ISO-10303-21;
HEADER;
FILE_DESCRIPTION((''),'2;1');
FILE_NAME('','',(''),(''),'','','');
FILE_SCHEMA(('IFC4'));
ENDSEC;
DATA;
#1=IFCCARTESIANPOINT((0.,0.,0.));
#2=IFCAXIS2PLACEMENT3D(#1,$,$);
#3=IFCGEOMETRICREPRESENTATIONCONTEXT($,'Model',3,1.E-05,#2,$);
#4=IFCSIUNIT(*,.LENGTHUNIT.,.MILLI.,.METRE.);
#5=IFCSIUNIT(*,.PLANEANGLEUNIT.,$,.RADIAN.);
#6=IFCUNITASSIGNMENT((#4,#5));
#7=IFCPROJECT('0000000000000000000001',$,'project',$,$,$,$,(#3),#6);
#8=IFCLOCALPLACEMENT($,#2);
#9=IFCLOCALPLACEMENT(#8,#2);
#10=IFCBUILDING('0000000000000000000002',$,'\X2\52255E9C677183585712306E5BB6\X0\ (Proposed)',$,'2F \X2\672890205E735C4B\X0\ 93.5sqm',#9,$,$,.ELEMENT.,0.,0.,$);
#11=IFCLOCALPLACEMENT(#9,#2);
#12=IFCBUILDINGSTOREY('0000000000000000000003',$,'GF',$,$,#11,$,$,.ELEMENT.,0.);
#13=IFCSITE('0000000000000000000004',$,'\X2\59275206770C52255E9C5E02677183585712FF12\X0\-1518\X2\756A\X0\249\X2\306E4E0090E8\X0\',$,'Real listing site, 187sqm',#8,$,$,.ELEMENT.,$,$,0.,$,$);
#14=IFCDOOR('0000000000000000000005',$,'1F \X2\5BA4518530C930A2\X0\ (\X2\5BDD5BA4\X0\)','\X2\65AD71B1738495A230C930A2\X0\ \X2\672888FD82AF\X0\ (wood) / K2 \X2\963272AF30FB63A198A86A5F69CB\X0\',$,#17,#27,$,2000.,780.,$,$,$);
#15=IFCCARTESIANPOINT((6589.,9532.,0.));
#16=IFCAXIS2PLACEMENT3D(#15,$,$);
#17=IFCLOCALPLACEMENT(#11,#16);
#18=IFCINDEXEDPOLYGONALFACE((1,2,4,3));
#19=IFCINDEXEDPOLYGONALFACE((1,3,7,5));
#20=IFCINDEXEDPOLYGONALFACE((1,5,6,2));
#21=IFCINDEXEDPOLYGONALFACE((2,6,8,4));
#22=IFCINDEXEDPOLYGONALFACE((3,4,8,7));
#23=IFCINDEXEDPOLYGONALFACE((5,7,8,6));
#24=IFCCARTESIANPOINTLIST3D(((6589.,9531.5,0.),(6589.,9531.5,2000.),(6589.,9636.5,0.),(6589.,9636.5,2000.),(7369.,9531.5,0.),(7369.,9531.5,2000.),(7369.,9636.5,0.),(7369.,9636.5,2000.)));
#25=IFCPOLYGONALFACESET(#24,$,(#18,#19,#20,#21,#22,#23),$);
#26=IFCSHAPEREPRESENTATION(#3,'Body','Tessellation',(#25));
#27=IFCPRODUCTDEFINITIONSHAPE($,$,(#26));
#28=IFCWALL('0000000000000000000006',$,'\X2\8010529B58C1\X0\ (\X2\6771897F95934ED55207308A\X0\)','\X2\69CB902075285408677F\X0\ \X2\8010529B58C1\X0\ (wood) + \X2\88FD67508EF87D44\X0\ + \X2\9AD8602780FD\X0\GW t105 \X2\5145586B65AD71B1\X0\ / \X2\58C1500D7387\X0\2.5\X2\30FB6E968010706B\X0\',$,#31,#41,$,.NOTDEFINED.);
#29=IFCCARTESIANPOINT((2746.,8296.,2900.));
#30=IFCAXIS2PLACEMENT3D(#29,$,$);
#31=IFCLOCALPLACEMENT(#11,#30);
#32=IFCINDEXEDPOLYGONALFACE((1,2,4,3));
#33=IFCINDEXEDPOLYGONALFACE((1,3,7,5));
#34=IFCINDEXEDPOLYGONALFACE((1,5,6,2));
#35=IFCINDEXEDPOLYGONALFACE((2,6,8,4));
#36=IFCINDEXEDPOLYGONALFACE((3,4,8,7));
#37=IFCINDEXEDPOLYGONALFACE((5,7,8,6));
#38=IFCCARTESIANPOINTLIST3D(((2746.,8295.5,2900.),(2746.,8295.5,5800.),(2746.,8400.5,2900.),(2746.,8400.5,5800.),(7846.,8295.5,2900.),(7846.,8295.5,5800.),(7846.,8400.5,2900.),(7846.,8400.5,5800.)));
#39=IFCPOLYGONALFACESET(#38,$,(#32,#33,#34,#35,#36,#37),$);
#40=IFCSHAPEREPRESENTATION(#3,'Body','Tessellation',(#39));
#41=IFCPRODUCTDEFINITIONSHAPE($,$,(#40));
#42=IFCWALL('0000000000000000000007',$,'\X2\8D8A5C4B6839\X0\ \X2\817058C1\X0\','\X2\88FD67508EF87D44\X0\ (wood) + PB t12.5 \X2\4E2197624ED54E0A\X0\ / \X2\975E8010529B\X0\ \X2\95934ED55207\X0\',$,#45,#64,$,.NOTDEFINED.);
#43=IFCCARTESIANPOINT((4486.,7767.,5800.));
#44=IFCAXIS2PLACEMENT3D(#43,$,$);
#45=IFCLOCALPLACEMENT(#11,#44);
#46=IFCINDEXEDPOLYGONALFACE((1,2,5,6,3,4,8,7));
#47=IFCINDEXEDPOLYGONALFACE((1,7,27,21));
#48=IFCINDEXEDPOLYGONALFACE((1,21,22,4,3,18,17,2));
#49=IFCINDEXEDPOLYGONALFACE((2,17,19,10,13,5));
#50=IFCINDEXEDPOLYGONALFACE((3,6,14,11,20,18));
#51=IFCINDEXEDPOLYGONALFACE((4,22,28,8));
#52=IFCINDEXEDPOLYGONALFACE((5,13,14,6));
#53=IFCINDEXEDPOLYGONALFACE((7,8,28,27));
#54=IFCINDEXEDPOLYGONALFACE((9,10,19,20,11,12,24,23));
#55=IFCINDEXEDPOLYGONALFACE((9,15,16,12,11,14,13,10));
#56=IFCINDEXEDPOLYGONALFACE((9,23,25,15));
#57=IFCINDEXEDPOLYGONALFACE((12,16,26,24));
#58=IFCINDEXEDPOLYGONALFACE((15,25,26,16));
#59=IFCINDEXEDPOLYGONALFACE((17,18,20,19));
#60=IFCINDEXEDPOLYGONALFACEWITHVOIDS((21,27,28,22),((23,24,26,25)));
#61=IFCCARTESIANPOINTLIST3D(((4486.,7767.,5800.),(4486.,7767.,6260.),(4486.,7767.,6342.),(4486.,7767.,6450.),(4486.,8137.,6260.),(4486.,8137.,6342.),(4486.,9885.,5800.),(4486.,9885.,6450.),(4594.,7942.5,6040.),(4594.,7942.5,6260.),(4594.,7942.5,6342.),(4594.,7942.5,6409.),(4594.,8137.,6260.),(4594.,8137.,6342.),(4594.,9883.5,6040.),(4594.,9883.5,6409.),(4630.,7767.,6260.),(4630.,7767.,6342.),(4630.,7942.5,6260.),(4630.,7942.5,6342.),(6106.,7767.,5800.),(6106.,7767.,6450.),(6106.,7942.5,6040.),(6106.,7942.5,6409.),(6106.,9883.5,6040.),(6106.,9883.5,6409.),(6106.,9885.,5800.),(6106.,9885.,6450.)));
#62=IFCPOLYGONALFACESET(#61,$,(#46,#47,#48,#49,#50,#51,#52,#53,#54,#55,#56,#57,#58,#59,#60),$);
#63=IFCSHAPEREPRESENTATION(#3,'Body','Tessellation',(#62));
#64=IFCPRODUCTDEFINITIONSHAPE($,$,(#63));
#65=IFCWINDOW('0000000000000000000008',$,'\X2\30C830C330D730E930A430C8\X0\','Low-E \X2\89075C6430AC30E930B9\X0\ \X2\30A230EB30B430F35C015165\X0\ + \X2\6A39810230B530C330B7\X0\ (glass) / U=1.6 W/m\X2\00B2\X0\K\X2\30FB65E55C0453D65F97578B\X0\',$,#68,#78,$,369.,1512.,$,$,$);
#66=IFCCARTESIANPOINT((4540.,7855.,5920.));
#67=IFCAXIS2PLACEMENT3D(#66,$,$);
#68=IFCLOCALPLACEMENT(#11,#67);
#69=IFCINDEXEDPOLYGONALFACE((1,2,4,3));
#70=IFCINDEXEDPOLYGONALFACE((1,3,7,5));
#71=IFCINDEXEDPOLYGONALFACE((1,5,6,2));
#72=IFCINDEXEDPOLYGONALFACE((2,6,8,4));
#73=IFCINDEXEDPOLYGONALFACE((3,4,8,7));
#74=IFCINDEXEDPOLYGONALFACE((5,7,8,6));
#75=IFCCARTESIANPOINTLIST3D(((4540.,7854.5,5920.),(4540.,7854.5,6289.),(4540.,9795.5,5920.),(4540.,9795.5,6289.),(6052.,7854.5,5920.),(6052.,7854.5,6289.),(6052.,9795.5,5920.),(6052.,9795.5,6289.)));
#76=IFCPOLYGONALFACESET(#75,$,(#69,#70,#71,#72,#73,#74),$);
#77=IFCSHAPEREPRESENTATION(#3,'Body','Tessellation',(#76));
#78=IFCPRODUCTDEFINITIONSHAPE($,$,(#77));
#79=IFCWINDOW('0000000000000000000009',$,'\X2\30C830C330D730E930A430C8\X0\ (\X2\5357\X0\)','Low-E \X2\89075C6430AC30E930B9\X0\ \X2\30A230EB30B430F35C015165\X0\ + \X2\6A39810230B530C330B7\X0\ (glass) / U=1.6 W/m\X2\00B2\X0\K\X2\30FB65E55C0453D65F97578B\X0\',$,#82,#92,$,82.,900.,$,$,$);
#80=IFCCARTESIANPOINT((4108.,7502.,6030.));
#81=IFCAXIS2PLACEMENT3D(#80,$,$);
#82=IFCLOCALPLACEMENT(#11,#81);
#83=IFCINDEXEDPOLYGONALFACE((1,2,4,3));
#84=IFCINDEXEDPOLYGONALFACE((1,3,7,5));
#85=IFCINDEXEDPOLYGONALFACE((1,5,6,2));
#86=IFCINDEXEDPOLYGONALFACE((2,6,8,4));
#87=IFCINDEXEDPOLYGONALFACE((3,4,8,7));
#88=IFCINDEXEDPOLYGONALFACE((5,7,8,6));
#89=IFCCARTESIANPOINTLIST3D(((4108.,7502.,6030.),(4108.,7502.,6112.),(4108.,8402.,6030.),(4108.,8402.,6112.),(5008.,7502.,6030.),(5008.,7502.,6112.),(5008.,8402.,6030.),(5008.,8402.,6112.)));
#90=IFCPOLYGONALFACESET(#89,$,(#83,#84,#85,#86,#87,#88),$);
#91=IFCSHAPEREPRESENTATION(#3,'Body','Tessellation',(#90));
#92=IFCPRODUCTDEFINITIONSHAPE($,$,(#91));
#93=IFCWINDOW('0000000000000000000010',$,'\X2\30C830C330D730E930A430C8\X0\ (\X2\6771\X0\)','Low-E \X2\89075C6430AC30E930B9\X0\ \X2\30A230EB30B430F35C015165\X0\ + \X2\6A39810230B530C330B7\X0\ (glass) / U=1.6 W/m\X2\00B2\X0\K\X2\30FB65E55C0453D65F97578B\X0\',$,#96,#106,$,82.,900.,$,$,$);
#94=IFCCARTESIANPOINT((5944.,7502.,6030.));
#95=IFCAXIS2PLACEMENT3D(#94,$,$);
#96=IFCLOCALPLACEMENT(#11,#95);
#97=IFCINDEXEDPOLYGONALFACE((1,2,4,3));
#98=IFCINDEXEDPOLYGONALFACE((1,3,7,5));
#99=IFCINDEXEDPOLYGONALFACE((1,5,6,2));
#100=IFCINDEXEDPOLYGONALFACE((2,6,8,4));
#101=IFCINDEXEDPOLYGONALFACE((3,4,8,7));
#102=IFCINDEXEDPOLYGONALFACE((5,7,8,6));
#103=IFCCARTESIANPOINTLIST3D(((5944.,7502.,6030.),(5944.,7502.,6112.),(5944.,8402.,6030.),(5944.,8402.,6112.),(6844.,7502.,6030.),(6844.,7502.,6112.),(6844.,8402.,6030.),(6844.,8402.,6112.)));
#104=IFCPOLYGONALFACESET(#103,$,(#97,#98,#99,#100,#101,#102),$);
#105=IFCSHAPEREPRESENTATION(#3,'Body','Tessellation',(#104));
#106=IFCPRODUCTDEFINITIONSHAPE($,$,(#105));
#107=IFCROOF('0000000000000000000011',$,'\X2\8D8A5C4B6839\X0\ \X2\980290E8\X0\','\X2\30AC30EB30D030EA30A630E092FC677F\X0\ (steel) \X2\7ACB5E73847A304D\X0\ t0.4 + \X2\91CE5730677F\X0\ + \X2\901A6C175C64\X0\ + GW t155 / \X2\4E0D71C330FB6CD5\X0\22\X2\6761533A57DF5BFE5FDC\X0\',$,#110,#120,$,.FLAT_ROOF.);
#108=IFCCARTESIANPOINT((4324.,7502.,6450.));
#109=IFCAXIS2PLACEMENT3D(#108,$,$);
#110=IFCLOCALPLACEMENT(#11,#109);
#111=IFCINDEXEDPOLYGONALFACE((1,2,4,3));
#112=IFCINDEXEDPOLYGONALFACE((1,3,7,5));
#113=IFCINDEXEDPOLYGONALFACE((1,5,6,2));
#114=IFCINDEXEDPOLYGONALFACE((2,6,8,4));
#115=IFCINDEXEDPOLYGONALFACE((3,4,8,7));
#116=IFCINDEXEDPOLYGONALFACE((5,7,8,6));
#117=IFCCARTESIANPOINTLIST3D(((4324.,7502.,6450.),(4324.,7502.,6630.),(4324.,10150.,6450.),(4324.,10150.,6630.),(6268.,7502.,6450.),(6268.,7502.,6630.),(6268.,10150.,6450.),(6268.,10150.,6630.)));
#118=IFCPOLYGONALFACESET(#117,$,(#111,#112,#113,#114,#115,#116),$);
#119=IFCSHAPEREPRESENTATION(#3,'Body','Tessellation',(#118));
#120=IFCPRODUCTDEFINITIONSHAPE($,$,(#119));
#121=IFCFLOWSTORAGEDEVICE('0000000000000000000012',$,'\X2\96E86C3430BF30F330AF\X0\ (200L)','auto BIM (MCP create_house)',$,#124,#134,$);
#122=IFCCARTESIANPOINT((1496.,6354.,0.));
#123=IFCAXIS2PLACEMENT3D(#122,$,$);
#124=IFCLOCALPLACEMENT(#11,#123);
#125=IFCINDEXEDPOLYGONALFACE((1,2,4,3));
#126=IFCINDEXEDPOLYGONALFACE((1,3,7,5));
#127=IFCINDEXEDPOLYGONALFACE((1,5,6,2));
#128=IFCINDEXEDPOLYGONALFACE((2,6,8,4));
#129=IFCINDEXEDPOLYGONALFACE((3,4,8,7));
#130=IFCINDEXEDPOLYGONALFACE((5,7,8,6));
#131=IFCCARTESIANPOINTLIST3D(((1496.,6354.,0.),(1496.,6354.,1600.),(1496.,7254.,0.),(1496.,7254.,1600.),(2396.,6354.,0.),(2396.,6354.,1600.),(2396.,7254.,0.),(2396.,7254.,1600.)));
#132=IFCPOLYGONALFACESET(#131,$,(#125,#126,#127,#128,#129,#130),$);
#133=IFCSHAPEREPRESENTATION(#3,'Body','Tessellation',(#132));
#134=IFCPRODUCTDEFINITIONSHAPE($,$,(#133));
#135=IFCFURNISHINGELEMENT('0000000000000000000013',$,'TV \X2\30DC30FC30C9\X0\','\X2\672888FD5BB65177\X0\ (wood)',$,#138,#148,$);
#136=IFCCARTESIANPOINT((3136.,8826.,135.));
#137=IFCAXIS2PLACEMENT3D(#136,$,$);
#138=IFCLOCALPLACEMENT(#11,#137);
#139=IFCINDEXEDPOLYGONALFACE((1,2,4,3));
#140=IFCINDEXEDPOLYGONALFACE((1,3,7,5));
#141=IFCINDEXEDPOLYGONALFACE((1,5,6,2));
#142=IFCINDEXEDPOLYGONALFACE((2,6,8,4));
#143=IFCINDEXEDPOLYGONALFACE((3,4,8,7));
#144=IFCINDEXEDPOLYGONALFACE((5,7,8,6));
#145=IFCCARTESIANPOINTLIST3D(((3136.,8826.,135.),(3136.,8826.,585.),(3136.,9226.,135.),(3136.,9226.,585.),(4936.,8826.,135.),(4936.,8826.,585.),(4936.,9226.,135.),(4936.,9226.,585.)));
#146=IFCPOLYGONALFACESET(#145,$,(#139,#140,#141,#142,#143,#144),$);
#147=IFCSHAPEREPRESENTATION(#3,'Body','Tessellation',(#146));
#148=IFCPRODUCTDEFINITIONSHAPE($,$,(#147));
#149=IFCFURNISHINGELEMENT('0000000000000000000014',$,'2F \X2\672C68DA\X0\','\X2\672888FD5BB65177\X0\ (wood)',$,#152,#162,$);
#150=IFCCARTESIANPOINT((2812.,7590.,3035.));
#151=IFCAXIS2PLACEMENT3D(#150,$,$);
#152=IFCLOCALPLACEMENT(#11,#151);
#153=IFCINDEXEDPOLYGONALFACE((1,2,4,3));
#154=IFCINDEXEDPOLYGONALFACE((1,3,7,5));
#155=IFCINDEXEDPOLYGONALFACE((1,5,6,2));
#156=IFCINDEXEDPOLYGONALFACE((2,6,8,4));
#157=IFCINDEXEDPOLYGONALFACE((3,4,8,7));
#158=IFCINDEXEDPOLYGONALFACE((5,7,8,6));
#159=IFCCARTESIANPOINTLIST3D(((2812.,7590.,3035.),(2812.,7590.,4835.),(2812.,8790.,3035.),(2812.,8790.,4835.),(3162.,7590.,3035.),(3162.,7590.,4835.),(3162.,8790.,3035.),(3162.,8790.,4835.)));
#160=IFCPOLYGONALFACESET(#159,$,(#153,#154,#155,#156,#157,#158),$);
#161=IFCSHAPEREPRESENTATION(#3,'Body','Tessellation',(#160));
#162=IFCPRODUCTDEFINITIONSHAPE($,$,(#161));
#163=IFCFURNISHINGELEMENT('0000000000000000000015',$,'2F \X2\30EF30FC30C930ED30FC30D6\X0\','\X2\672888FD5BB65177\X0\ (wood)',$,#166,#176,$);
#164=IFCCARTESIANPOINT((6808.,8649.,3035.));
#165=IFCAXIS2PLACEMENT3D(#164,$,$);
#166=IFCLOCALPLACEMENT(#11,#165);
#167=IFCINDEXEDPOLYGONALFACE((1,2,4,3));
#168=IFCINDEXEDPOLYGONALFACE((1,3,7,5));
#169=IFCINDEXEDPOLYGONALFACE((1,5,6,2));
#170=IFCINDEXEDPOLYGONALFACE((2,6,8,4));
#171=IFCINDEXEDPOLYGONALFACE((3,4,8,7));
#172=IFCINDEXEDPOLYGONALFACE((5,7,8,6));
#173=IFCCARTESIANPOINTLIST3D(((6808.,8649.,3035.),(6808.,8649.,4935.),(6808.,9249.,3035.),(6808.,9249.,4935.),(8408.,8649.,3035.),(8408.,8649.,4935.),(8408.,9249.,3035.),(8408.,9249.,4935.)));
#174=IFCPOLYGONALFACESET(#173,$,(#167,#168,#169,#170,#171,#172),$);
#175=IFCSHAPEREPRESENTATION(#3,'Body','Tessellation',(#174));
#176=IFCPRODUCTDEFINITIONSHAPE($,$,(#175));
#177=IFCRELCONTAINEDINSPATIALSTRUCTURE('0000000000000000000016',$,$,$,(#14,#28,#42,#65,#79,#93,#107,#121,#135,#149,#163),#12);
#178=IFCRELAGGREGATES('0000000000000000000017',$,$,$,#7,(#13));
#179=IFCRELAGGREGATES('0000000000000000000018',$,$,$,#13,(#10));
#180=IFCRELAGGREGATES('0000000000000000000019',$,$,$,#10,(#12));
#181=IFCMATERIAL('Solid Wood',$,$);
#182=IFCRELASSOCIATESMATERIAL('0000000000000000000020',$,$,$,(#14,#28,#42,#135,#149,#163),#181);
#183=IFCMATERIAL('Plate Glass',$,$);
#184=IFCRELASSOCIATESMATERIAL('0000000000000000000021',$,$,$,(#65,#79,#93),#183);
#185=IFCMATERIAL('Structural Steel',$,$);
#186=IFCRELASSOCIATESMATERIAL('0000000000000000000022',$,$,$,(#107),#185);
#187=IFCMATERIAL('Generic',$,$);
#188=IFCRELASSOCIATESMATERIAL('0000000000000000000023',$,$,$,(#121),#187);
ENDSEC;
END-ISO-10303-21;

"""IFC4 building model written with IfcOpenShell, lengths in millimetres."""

from ifc_helpers import new_model, si_unit, frame, frame_2d, origin, place, context, project, spatial, rectangle, extrude, material, element, fill, save


model = new_model("IFC4")

# Units and contexts
model_context = context("Model", 3, precision=1e-05, world=origin())
ifc_project = project(units=[si_unit("LENGTHUNIT", "METRE", prefix="MILLI"), si_unit("PLANEANGLEUNIT", "RADIAN")], contexts=[model_context])

# Site, building, storey
site_placement = place(None, origin())
site = spatial("IfcSite", under=ifc_project, at=site_placement, Name="大分県別府市東荘園２-1518番249の一部", ObjectType="Real listing site, 187sqm", CompositionType="ELEMENT", RefElevation=0.0)
building_placement = place(site_placement, origin())
building = spatial("IfcBuilding", under=site, at=building_placement, Name="別府東荘園の家 (Proposed)", ObjectType="2F 木造平屋 93.5sqm", CompositionType="ELEMENT", ElevationOfRefHeight=0.0, ElevationOfTerrain=0.0)
storey_placement = place(building_placement, origin())
storey = spatial("IfcBuildingStorey", under=building, at=storey_placement, Name="GF", CompositionType="ELEMENT", Elevation=0.0)

# Shared definitions
ifc_material_1 = material(Name="Solid Wood")

# Door
door_placement = place(storey_placement, frame((6589.0, 9532.0, 0.0)))
element("IfcDoor", 1, at=door_placement, inside=storey, material=ifc_material_1, Name="1F 室内ドア (寝室)", Description="断熱玄関ドア 木製芯 (wood) / K2 防犯・採風機構", OverallHeight=2000.0, OverallWidth=780.0, context=model_context, shape_type="SweptSolid", body=[
    extrude(rectangle(XDim=780.0, YDim=105.0, at=frame_2d((390.0, 52.0))), frame((6589.0, 9532.0, 0.0)), (0.0, 0.0, 1.0), 2000.0),
])

# Wall
wall_1_placement = place(storey_placement, frame((2746.0, 8296.0, 2900.0)))
element("IfcWall", 2, at=wall_1_placement, inside=storey, material=ifc_material_1, Name="耐力壁 (東西間仕切り)", Description="構造用合板 耐力壁 (wood) + 製材軸組 + 高性能GW t105 充填断熱 / 壁倍率2.5・準耐火", PredefinedType="NOTDEFINED", context=model_context, shape_type="SweptSolid", body=[
    extrude(rectangle(XDim=5100.0, YDim=105.0, at=frame_2d((2550.0, 52.0))), frame((2746.0, 8296.0, 2900.0)), (0.0, 0.0, 1.0), 2900.0),
])

# Wall, openings, windows
wall_2_placement = place(storey_placement, frame((4486.0, 7767.0, 5800.0)))
wall_2 = element("IfcWall", 3, at=wall_2_placement, inside=storey, material=ifc_material_1, Name="越屋根 腰壁", Description="製材軸組 (wood) + PB t12.5 両面仕上 / 非耐力 間仕切", PredefinedType="NOTDEFINED", context=model_context, shape_type="SweptSolid", body=[
    extrude(rectangle(XDim=1620.0, YDim=2118.0, at=frame_2d((810.0, 1059.0))), frame((4486.0, 7767.0, 5800.0)), (0.0, 0.0, 1.0), 650.0),
])
opening_1_placement = place(storey_placement, frame((4540.0, 7855.0, 5920.0)))
opening_1 = element("IfcOpeningElement", 4, at=opening_1_placement, cuts=wall_2, PredefinedType="NOTDEFINED", context=model_context, shape_type="SweptSolid", body=[
    extrude(rectangle(XDim=1512.0, YDim=1941.0, at=frame_2d((756.0, 970.0))), frame((4540.0, 7855.0, 5920.0)), (0.0, 0.0, 1.0), 369.0),
])
opening_2_placement = place(storey_placement, frame((4108.0, 7502.0, 6030.0)))
opening_2 = element("IfcOpeningElement", 5, at=opening_2_placement, cuts=wall_2, PredefinedType="NOTDEFINED", context=model_context, shape_type="SweptSolid", body=[
    extrude(rectangle(XDim=900.0, YDim=900.0, at=frame_2d((450.0, 450.0))), frame((4108.0, 7502.0, 6030.0)), (0.0, 0.0, 1.0), 82.0),
])
opening_3_placement = place(storey_placement, frame((5944.0, 7502.0, 6030.0)))
opening_3 = element("IfcOpeningElement", 6, at=opening_3_placement, cuts=wall_2, PredefinedType="NOTDEFINED", context=model_context, shape_type="SweptSolid", body=[
    extrude(rectangle(XDim=900.0, YDim=900.0, at=frame_2d((450.0, 450.0))), frame((5944.0, 7502.0, 6030.0)), (0.0, 0.0, 1.0), 82.0),
])
ifc_material_2 = material(Name="Plate Glass")
window_1_placement = place(storey_placement, frame((4540.0, 7855.0, 5920.0)))
window_1 = element("IfcWindow", 7, at=window_1_placement, inside=storey, material=ifc_material_2, Name="トップライト", Description="Low-E 複層ガラス アルゴン封入 + 樹脂サッシ (glass) / U=1.6 W/m²K・日射取得型", OverallHeight=369.0, OverallWidth=1512.0, context=model_context, shape_type="SweptSolid", body=[
    extrude(rectangle(XDim=1512.0, YDim=1941.0, at=frame_2d((756.0, 970.0))), frame((4540.0, 7855.0, 5920.0)), (0.0, 0.0, 1.0), 369.0),
])
fill(opening_1, window_1)
window_2_placement = place(storey_placement, frame((4108.0, 7502.0, 6030.0)))
window_2 = element("IfcWindow", 8, at=window_2_placement, inside=storey, material=ifc_material_2, Name="トップライト (南)", Description="Low-E 複層ガラス アルゴン封入 + 樹脂サッシ (glass) / U=1.6 W/m²K・日射取得型", OverallHeight=82.0, OverallWidth=900.0, context=model_context, shape_type="SweptSolid", body=[
    extrude(rectangle(XDim=900.0, YDim=900.0, at=frame_2d((450.0, 450.0))), frame((4108.0, 7502.0, 6030.0)), (0.0, 0.0, 1.0), 82.0),
])
fill(opening_2, window_2)
window_3_placement = place(storey_placement, frame((5944.0, 7502.0, 6030.0)))
window_3 = element("IfcWindow", 9, at=window_3_placement, inside=storey, material=ifc_material_2, Name="トップライト (東)", Description="Low-E 複層ガラス アルゴン封入 + 樹脂サッシ (glass) / U=1.6 W/m²K・日射取得型", OverallHeight=82.0, OverallWidth=900.0, context=model_context, shape_type="SweptSolid", body=[
    extrude(rectangle(XDim=900.0, YDim=900.0, at=frame_2d((450.0, 450.0))), frame((5944.0, 7502.0, 6030.0)), (0.0, 0.0, 1.0), 82.0),
])
fill(opening_3, window_3)

# Roof
ifc_material_3 = material(Name="Structural Steel")
roof_placement = place(storey_placement, frame((4324.0, 7502.0, 6450.0)))
element("IfcRoof", 10, at=roof_placement, inside=storey, material=ifc_material_3, Name="越屋根 頂部", Description="ガルバリウム鋼板 (steel) 立平葺き t0.4 + 野地板 + 通気層 + GW t155 / 不燃・法22条区域対応", PredefinedType="FLAT_ROOF", context=model_context, shape_type="SweptSolid", body=[
    extrude(rectangle(XDim=1944.0, YDim=2648.0, at=frame_2d((972.0, 1324.0))), frame((4324.0, 7502.0, 6450.0)), (0.0, 0.0, 1.0), 180.0),
])

# Flow storage device
ifc_material_4 = material(Name="Generic")
flow_storage_device_placement = place(storey_placement, frame((1496.0, 6354.0, 0.0)))
element("IfcFlowStorageDevice", 11, at=flow_storage_device_placement, inside=storey, material=ifc_material_4, Name="雨水タンク (200L)", Description="auto BIM (MCP create_house)", context=model_context, shape_type="SweptSolid", body=[
    extrude(rectangle(XDim=900.0, YDim=900.0, at=frame_2d((450.0, 450.0))), frame((1496.0, 6354.0, 0.0)), (0.0, 0.0, 1.0), 1600.0),
])

# Furnishing elements
furnishing_1_placement = place(storey_placement, frame((3136.0, 8826.0, 135.0)))
element("IfcFurnishingElement", 12, at=furnishing_1_placement, inside=storey, material=ifc_material_1, Name="TV ボード", Description="木製家具 (wood)", context=model_context, shape_type="SweptSolid", body=[
    extrude(rectangle(XDim=1800.0, YDim=400.0, at=frame_2d((900.0, 200.0))), frame((3136.0, 8826.0, 135.0)), (0.0, 0.0, 1.0), 450.0),
])
furnishing_2_placement = place(storey_placement, frame((2812.0, 7590.0, 3035.0)))
element("IfcFurnishingElement", 13, at=furnishing_2_placement, inside=storey, material=ifc_material_1, Name="2F 本棚", Description="木製家具 (wood)", context=model_context, shape_type="SweptSolid", body=[
    extrude(rectangle(XDim=350.0, YDim=1200.0, at=frame_2d((175.0, 600.0))), frame((2812.0, 7590.0, 3035.0)), (0.0, 0.0, 1.0), 1800.0),
])
furnishing_3_placement = place(storey_placement, frame((6808.0, 8649.0, 3035.0)))
element("IfcFurnishingElement", 14, at=furnishing_3_placement, inside=storey, material=ifc_material_1, Name="2F ワードローブ", Description="木製家具 (wood)", context=model_context, shape_type="SweptSolid", body=[
    extrude(rectangle(XDim=1600.0, YDim=600.0, at=frame_2d((800.0, 300.0))), frame((6808.0, 8649.0, 3035.0)), (0.0, 0.0, 1.0), 1900.0),
])

save(model, "model.ifc")
